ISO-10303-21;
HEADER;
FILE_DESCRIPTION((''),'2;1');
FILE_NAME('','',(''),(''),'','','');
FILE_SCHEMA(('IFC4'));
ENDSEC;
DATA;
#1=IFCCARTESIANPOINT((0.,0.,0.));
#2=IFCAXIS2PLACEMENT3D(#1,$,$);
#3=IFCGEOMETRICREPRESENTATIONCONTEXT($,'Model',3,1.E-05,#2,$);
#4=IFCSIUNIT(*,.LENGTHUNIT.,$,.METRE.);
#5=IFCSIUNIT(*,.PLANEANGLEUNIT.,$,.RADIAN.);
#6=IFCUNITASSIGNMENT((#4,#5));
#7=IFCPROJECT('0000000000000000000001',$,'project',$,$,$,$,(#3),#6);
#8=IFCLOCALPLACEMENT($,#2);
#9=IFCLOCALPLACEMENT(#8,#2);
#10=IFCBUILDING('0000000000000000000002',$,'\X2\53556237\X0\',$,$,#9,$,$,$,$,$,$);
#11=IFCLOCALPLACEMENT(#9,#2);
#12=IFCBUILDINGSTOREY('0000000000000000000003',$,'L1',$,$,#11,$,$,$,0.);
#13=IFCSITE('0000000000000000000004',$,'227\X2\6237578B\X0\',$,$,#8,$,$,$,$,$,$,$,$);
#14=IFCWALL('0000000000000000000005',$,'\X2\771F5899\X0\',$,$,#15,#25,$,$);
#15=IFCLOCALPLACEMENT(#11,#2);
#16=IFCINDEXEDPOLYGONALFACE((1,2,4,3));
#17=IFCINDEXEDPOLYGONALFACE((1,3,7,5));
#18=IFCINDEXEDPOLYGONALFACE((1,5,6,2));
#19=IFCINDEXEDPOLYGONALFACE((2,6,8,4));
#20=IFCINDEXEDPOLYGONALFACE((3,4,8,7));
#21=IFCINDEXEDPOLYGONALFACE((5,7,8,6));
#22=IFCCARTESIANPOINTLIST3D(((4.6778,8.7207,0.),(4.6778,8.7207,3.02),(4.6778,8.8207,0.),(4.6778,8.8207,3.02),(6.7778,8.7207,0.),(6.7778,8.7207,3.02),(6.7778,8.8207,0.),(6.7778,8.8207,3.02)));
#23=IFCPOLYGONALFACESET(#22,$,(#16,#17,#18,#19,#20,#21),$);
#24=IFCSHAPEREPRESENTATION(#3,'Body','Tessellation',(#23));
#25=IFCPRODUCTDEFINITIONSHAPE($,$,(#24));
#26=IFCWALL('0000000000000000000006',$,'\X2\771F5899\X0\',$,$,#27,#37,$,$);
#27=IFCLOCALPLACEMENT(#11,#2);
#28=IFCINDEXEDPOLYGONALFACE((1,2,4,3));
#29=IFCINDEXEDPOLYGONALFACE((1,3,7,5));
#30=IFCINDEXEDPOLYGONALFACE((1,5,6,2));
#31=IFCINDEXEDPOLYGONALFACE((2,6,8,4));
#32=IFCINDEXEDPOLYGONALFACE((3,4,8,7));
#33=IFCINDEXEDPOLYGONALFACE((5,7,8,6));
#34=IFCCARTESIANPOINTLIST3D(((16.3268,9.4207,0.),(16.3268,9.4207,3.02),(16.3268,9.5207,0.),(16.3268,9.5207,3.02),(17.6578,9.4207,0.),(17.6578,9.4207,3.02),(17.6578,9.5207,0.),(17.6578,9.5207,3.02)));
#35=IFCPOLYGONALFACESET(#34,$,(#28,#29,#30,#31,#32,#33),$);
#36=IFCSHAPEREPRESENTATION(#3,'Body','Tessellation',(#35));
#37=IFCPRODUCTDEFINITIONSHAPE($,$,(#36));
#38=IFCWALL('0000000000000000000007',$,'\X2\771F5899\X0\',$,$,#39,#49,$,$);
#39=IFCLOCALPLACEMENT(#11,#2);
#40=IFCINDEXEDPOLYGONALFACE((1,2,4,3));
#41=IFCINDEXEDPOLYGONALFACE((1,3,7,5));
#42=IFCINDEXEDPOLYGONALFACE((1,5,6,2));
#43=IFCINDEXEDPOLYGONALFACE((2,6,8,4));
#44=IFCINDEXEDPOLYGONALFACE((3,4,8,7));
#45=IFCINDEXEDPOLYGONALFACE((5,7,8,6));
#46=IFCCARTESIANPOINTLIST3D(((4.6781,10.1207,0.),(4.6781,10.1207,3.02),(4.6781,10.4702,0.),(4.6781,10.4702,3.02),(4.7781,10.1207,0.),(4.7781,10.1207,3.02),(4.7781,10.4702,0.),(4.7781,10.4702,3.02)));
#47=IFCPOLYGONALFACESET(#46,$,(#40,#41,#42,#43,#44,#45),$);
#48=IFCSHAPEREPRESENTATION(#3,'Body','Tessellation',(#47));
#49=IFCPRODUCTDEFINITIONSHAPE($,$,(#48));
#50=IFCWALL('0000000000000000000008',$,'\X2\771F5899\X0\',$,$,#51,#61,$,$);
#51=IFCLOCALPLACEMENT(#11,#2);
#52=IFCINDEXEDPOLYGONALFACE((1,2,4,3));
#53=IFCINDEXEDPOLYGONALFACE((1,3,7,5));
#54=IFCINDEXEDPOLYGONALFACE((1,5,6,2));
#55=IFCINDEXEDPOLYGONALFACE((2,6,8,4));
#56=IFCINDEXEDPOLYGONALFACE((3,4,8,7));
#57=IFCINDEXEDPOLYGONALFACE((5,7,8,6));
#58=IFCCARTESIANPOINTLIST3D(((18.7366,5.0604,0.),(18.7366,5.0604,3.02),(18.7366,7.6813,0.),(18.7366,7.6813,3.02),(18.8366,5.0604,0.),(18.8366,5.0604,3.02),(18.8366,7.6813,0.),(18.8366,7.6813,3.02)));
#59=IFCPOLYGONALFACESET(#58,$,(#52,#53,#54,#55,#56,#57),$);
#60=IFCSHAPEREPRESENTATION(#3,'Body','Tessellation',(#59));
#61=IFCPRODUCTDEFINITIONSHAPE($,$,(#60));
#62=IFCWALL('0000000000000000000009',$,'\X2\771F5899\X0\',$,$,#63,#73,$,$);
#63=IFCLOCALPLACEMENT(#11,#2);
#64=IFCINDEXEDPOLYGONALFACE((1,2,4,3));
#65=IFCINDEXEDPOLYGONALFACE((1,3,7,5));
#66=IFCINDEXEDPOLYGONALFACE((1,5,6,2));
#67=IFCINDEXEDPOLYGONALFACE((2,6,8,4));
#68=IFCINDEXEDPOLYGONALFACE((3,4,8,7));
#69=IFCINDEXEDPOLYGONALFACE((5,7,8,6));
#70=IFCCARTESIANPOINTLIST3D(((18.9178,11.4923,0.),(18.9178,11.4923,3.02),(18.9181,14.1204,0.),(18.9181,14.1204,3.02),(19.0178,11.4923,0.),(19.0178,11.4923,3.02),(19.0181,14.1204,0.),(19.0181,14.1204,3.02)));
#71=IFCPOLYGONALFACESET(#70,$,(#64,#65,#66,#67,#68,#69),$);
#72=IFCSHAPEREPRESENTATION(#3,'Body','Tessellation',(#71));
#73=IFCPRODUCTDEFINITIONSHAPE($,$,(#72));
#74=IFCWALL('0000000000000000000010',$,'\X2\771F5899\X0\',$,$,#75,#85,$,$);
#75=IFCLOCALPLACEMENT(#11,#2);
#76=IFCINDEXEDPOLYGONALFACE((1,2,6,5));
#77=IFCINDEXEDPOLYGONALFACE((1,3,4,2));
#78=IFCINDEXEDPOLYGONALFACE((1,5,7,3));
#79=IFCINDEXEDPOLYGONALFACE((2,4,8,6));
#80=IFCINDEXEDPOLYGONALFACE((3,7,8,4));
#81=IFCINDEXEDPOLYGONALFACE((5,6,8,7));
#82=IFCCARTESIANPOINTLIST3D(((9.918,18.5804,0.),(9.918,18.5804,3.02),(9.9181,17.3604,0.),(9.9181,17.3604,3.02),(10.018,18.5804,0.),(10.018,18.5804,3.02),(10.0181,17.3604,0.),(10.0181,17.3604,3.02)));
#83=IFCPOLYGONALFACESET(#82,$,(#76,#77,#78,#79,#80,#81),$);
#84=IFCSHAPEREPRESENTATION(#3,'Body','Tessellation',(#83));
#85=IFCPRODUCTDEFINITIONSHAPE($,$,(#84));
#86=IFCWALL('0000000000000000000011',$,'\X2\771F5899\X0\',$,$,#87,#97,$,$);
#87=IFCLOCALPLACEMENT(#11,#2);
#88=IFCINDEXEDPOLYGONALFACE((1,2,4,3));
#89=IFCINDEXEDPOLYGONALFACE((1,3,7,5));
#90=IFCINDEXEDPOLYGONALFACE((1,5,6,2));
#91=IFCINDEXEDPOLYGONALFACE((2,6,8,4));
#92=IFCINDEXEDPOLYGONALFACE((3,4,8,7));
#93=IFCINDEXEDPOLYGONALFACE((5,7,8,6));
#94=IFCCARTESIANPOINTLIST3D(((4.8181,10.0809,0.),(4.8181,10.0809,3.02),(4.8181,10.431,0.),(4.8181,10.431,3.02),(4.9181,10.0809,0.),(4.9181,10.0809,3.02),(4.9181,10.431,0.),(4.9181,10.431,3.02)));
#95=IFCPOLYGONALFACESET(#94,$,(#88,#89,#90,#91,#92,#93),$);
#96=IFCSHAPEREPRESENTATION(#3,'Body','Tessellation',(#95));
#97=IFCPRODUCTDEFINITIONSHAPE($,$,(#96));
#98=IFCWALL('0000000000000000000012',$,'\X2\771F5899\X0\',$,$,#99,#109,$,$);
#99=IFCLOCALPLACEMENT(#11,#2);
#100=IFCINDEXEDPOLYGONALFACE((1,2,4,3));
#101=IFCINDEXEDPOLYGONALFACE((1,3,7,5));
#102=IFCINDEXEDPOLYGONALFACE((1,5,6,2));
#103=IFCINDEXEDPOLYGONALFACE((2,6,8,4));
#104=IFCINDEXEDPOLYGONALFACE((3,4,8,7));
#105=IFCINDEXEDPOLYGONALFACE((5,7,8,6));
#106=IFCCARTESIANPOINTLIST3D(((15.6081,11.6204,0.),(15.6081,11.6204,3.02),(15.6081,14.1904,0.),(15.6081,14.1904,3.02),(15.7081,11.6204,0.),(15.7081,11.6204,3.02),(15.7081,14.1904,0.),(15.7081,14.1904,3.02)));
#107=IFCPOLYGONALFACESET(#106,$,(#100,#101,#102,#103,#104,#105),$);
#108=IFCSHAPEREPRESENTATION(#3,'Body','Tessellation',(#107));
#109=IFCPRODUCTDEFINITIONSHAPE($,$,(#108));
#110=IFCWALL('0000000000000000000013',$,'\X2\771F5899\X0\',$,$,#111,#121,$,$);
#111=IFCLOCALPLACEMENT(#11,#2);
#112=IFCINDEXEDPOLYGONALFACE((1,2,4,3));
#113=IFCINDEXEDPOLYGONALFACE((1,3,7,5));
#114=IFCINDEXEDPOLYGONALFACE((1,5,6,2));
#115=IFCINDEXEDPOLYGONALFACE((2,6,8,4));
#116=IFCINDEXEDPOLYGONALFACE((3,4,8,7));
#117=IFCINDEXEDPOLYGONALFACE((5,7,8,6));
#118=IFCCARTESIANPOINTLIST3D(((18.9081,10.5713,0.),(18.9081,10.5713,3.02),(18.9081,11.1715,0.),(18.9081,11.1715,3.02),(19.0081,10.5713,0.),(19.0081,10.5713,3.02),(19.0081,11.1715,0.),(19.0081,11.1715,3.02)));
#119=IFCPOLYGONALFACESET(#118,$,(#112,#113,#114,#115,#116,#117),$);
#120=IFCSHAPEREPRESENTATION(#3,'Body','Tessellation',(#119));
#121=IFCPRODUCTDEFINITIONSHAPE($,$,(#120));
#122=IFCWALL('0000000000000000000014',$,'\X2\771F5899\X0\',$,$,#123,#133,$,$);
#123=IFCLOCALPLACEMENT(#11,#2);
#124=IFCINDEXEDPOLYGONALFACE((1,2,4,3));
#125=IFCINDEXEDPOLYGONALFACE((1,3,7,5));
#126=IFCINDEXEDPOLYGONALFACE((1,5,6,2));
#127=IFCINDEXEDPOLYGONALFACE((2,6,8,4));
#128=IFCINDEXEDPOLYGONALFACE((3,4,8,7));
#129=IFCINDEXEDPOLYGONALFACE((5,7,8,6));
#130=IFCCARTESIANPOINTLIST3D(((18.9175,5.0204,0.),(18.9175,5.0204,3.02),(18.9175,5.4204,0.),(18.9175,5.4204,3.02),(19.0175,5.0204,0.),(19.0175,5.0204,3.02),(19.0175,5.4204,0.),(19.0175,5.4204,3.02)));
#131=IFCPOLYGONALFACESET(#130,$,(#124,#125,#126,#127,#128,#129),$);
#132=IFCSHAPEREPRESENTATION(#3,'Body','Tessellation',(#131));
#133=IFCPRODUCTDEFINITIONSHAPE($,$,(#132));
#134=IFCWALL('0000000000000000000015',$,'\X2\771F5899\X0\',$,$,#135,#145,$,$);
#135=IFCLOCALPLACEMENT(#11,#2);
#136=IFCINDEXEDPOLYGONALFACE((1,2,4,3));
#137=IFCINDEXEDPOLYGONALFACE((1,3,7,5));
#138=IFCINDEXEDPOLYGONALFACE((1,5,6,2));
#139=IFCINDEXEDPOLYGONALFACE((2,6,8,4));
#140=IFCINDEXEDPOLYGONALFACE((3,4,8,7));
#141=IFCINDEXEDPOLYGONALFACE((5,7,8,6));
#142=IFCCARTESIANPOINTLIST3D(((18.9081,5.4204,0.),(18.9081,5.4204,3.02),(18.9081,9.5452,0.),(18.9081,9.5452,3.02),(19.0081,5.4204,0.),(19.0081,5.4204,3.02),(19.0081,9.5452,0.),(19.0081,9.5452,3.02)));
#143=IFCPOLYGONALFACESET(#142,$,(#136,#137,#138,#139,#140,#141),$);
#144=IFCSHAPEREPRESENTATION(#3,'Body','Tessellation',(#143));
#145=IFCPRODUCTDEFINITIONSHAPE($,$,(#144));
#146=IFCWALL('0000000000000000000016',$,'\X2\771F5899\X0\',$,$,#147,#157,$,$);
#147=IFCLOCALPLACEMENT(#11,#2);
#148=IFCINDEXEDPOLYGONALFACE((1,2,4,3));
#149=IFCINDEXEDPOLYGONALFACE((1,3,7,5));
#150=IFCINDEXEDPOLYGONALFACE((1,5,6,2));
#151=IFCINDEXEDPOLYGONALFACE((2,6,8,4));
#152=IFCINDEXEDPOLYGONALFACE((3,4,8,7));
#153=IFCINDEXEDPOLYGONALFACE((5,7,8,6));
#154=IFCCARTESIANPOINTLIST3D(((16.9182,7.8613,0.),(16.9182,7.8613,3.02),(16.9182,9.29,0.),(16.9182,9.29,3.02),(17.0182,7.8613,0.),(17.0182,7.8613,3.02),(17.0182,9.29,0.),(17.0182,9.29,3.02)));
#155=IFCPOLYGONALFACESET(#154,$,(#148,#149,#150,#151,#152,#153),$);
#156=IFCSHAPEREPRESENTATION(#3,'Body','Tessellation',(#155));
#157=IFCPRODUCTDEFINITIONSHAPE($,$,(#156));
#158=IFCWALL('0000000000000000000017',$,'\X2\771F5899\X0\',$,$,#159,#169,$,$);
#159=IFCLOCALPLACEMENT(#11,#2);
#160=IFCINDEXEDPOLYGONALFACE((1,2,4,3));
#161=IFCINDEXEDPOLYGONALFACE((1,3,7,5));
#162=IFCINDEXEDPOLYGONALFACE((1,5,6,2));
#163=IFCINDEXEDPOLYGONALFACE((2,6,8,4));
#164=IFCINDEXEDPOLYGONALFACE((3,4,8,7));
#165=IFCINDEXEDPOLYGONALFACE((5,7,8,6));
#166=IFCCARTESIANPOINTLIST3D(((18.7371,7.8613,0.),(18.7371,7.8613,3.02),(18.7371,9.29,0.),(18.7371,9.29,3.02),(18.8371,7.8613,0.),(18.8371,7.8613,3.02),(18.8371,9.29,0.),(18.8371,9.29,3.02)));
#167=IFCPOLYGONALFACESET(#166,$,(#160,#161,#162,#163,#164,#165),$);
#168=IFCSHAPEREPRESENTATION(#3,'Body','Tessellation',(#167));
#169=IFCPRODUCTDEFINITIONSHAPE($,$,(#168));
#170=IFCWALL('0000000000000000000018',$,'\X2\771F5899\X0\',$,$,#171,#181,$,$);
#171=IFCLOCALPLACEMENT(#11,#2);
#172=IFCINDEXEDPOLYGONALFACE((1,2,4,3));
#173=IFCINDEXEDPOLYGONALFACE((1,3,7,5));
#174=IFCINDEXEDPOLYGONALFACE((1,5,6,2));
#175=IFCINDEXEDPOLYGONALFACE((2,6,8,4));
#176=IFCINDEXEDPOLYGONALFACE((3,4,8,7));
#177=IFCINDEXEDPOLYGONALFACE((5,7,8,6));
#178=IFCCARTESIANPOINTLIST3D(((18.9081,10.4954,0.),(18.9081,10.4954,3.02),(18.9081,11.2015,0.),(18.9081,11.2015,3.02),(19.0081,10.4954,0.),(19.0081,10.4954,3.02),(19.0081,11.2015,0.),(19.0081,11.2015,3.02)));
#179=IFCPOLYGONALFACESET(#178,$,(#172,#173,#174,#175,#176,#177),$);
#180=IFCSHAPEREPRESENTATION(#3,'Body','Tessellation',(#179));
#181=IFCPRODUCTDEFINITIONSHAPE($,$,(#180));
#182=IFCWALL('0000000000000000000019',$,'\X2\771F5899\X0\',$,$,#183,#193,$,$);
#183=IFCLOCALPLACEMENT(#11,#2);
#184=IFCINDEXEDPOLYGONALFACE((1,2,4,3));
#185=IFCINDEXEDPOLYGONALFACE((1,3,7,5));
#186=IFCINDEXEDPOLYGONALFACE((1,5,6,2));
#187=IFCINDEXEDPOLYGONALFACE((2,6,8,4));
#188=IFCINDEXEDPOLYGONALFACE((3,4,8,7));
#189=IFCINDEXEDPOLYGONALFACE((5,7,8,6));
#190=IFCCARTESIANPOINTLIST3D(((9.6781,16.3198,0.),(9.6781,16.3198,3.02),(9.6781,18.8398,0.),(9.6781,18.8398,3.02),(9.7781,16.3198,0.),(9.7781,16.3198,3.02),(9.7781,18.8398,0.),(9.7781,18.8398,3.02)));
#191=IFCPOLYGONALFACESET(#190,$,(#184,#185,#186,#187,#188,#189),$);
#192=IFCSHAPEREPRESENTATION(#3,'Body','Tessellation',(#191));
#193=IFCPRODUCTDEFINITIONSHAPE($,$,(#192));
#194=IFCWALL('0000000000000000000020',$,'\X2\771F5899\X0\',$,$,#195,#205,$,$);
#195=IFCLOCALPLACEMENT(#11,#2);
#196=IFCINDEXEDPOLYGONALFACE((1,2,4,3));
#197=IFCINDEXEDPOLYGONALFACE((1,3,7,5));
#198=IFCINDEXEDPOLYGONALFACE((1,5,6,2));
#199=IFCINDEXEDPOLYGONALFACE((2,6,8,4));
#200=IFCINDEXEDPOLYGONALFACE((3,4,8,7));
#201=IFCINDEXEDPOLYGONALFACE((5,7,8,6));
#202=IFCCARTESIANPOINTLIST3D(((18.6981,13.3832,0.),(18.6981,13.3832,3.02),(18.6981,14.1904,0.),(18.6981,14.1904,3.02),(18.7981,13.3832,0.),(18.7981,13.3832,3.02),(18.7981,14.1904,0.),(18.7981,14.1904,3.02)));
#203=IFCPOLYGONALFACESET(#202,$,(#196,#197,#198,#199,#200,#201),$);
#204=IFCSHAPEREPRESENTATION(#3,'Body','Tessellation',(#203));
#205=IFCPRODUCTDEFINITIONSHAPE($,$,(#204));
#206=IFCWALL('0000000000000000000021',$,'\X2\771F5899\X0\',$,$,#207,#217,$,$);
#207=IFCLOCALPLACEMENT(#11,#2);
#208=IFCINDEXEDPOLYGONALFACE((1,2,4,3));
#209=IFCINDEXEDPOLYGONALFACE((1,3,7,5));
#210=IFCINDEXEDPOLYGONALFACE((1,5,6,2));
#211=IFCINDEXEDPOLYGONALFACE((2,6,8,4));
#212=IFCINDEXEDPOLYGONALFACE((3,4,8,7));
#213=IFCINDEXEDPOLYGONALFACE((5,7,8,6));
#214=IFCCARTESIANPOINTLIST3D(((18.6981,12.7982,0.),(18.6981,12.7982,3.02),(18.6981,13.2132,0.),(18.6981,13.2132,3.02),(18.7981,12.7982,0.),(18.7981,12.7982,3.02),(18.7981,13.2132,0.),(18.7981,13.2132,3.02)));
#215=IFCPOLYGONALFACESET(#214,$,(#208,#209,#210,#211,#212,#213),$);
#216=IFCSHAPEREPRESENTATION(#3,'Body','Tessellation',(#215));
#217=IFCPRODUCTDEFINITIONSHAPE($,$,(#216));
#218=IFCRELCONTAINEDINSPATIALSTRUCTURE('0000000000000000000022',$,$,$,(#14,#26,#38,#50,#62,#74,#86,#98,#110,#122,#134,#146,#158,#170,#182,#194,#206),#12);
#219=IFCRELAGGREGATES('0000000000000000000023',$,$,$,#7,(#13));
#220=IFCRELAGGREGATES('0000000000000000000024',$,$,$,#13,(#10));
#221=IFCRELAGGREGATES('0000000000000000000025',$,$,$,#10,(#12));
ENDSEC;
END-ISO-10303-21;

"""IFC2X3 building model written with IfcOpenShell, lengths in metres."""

from ifc_helpers import new_model, si_unit, origin, place, context, project, spatial, polyline, outline, extrude, element, save


model = new_model("IFC2X3")

# Units and contexts
model_context = context("Model", 3, precision=1e-05, world=origin())
ifc_project = project(units=[si_unit("LENGTHUNIT", "METRE"), si_unit("PLANEANGLEUNIT", "RADIAN")], contexts=[model_context])

# Site, building, storey
site_placement = place(None, origin())
site = spatial("IfcSite", under=ifc_project, at=site_placement, Name="227户型")
building_placement = place(site_placement, origin())
building = spatial("IfcBuilding", under=site, at=building_placement, Name="单户")
storey_placement = place(building_placement, origin())
storey = spatial("IfcBuildingStorey", under=building, at=storey_placement, Name="L1", Elevation=0.0)

# Walls
wall_1_placement = place(storey_placement, origin())
element("IfcWall", 1, at=wall_1_placement, inside=storey, Name="真墙", context=model_context, shape_type="SweptSolid", body=[
    extrude(outline(polyline([(6.7778, 8.7207), (4.6778, 8.7207), (4.6778, 8.8207), (6.7778, 8.8207), (6.7778, 8.7207)])), origin(), (0.0, 0.0, 1.0), 3.02),
])
wall_2_placement = place(storey_placement, origin())
element("IfcWall", 2, at=wall_2_placement, inside=storey, Name="真墙", context=model_context, shape_type="SweptSolid", body=[
    extrude(outline(polyline([(16.3268, 9.5207), (17.6578, 9.5207), (17.6578, 9.4207), (16.3268, 9.4207), (16.3268, 9.5207)])), origin(), (0.0, 0.0, 1.0), 3.02),
])
wall_3_placement = place(storey_placement, origin())
element("IfcWall", 3, at=wall_3_placement, inside=storey, Name="真墙", context=model_context, shape_type="SweptSolid", body=[
    extrude(outline(polyline([(4.6781, 10.1207), (4.6781, 10.4702), (4.7781, 10.4702), (4.7781, 10.1207), (4.6781, 10.1207)])), origin(), (0.0, 0.0, 1.0), 3.02),
])
wall_4_placement = place(storey_placement, origin())
element("IfcWall", 4, at=wall_4_placement, inside=storey, Name="真墙", context=model_context, shape_type="SweptSolid", body=[
    extrude(outline(polyline([(18.8366, 7.6813), (18.8366, 5.0604), (18.7366, 5.0604), (18.7366, 7.6813), (18.8366, 7.6813)])), origin(), (0.0, 0.0, 1.0), 3.02),
])
wall_5_placement = place(storey_placement, origin())
element("IfcWall", 5, at=wall_5_placement, inside=storey, Name="真墙", context=model_context, shape_type="SweptSolid", body=[
    extrude(outline(polyline([(18.9178, 11.4923), (18.9181, 14.1204), (19.0181, 14.1204), (19.0178, 11.4923), (18.9178, 11.4923)])), origin(), (0.0, 0.0, 1.0), 3.02),
])
wall_6_placement = place(storey_placement, origin())
element("IfcWall", 6, at=wall_6_placement, inside=storey, Name="真墙", context=model_context, shape_type="SweptSolid", body=[
    extrude(outline(polyline([(10.018, 18.5804), (10.0181, 17.3604), (9.9181, 17.3604), (9.918, 18.5804), (10.018, 18.5804)])), origin(), (0.0, 0.0, 1.0), 3.02),
])
wall_7_placement = place(storey_placement, origin())
element("IfcWall", 7, at=wall_7_placement, inside=storey, Name="真墙", context=model_context, shape_type="SweptSolid", body=[
    extrude(outline(polyline([(4.9181, 10.431), (4.9181, 10.0809), (4.8181, 10.0809), (4.8181, 10.431), (4.9181, 10.431)])), origin(), (0.0, 0.0, 1.0), 3.02),
])

# Wall
wall_8_placement = place(storey_placement, origin())
element("IfcWall", 8, at=wall_8_placement, inside=storey, Name="真墙", context=model_context, shape_type="SweptSolid", body=[
    extrude(outline(polyline([(15.7081, 14.1904), (15.7081, 11.6204), (15.6081, 11.6204), (15.6081, 14.1904), (15.7081, 14.1904)])), origin(), (0.0, 0.0, 1.0), 3.02),
])

# Walls
wall_9_placement = place(storey_placement, origin())
element("IfcWall", 9, at=wall_9_placement, inside=storey, Name="真墙", context=model_context, shape_type="SweptSolid", body=[
    extrude(outline(polyline([(19.0081, 11.1715), (19.0081, 10.5713), (18.9081, 10.5713), (18.9081, 11.1715), (19.0081, 11.1715)])), origin(), (0.0, 0.0, 1.0), 3.02),
])
wall_10_placement = place(storey_placement, origin())
element("IfcWall", 10, at=wall_10_placement, inside=storey, Name="真墙", context=model_context, shape_type="SweptSolid", body=[
    extrude(outline(polyline([(19.0175, 5.4204), (19.0175, 5.0204), (18.9175, 5.0204), (18.9175, 5.4204), (19.0175, 5.4204)])), origin(), (0.0, 0.0, 1.0), 3.02),
])
wall_11_placement = place(storey_placement, origin())
element("IfcWall", 11, at=wall_11_placement, inside=storey, Name="真墙", context=model_context, shape_type="SweptSolid", body=[
    extrude(outline(polyline([(18.9081, 5.4204), (18.9081, 9.5452), (19.0081, 9.5452), (19.0081, 5.4204), (18.9081, 5.4204)])), origin(), (0.0, 0.0, 1.0), 3.02),
])
wall_12_placement = place(storey_placement, origin())
element("IfcWall", 12, at=wall_12_placement, inside=storey, Name="真墙", context=model_context, shape_type="SweptSolid", body=[
    extrude(outline(polyline([(17.0182, 9.29), (17.0182, 7.8613), (16.9182, 7.8613), (16.9182, 9.29), (17.0182, 9.29)])), origin(), (0.0, 0.0, 1.0), 3.02),
])
wall_13_placement = place(storey_placement, origin())
element("IfcWall", 13, at=wall_13_placement, inside=storey, Name="真墙", context=model_context, shape_type="SweptSolid", body=[
    extrude(outline(polyline([(18.7371, 7.8613), (18.7371, 9.29), (18.8371, 9.29), (18.8371, 7.8613), (18.7371, 7.8613)])), origin(), (0.0, 0.0, 1.0), 3.02),
])
wall_14_placement = place(storey_placement, origin())
element("IfcWall", 14, at=wall_14_placement, inside=storey, Name="真墙", context=model_context, shape_type="SweptSolid", body=[
    extrude(outline(polyline([(19.0081, 11.2015), (19.0081, 10.4954), (18.9081, 10.4954), (18.9081, 11.2015), (19.0081, 11.2015)])), origin(), (0.0, 0.0, 1.0), 3.02),
])
wall_15_placement = place(storey_placement, origin())
element("IfcWall", 15, at=wall_15_placement, inside=storey, Name="真墙", context=model_context, shape_type="SweptSolid", body=[
    extrude(outline(polyline([(9.6781, 16.3198), (9.6781, 18.8398), (9.7781, 18.8398), (9.7781, 16.3198), (9.6781, 16.3198)])), origin(), (0.0, 0.0, 1.0), 3.02),
])

# Walls
wall_16_placement = place(storey_placement, origin())
element("IfcWall", 16, at=wall_16_placement, inside=storey, Name="真墙", context=model_context, shape_type="SweptSolid", body=[
    extrude(outline(polyline([(18.6981, 13.3832), (18.6981, 14.1904), (18.7981, 14.1904), (18.7981, 13.3832), (18.6981, 13.3832)])), origin(), (0.0, 0.0, 1.0), 3.02),
])
wall_17_placement = place(storey_placement, origin())
element("IfcWall", 17, at=wall_17_placement, inside=storey, Name="真墙", context=model_context, shape_type="SweptSolid", body=[
    extrude(outline(polyline([(18.7981, 13.2132), (18.7981, 12.7982), (18.6981, 12.7982), (18.6981, 13.2132), (18.7981, 13.2132)])), origin(), (0.0, 0.0, 1.0), 3.02),
])

save(model, "model.ifc")
